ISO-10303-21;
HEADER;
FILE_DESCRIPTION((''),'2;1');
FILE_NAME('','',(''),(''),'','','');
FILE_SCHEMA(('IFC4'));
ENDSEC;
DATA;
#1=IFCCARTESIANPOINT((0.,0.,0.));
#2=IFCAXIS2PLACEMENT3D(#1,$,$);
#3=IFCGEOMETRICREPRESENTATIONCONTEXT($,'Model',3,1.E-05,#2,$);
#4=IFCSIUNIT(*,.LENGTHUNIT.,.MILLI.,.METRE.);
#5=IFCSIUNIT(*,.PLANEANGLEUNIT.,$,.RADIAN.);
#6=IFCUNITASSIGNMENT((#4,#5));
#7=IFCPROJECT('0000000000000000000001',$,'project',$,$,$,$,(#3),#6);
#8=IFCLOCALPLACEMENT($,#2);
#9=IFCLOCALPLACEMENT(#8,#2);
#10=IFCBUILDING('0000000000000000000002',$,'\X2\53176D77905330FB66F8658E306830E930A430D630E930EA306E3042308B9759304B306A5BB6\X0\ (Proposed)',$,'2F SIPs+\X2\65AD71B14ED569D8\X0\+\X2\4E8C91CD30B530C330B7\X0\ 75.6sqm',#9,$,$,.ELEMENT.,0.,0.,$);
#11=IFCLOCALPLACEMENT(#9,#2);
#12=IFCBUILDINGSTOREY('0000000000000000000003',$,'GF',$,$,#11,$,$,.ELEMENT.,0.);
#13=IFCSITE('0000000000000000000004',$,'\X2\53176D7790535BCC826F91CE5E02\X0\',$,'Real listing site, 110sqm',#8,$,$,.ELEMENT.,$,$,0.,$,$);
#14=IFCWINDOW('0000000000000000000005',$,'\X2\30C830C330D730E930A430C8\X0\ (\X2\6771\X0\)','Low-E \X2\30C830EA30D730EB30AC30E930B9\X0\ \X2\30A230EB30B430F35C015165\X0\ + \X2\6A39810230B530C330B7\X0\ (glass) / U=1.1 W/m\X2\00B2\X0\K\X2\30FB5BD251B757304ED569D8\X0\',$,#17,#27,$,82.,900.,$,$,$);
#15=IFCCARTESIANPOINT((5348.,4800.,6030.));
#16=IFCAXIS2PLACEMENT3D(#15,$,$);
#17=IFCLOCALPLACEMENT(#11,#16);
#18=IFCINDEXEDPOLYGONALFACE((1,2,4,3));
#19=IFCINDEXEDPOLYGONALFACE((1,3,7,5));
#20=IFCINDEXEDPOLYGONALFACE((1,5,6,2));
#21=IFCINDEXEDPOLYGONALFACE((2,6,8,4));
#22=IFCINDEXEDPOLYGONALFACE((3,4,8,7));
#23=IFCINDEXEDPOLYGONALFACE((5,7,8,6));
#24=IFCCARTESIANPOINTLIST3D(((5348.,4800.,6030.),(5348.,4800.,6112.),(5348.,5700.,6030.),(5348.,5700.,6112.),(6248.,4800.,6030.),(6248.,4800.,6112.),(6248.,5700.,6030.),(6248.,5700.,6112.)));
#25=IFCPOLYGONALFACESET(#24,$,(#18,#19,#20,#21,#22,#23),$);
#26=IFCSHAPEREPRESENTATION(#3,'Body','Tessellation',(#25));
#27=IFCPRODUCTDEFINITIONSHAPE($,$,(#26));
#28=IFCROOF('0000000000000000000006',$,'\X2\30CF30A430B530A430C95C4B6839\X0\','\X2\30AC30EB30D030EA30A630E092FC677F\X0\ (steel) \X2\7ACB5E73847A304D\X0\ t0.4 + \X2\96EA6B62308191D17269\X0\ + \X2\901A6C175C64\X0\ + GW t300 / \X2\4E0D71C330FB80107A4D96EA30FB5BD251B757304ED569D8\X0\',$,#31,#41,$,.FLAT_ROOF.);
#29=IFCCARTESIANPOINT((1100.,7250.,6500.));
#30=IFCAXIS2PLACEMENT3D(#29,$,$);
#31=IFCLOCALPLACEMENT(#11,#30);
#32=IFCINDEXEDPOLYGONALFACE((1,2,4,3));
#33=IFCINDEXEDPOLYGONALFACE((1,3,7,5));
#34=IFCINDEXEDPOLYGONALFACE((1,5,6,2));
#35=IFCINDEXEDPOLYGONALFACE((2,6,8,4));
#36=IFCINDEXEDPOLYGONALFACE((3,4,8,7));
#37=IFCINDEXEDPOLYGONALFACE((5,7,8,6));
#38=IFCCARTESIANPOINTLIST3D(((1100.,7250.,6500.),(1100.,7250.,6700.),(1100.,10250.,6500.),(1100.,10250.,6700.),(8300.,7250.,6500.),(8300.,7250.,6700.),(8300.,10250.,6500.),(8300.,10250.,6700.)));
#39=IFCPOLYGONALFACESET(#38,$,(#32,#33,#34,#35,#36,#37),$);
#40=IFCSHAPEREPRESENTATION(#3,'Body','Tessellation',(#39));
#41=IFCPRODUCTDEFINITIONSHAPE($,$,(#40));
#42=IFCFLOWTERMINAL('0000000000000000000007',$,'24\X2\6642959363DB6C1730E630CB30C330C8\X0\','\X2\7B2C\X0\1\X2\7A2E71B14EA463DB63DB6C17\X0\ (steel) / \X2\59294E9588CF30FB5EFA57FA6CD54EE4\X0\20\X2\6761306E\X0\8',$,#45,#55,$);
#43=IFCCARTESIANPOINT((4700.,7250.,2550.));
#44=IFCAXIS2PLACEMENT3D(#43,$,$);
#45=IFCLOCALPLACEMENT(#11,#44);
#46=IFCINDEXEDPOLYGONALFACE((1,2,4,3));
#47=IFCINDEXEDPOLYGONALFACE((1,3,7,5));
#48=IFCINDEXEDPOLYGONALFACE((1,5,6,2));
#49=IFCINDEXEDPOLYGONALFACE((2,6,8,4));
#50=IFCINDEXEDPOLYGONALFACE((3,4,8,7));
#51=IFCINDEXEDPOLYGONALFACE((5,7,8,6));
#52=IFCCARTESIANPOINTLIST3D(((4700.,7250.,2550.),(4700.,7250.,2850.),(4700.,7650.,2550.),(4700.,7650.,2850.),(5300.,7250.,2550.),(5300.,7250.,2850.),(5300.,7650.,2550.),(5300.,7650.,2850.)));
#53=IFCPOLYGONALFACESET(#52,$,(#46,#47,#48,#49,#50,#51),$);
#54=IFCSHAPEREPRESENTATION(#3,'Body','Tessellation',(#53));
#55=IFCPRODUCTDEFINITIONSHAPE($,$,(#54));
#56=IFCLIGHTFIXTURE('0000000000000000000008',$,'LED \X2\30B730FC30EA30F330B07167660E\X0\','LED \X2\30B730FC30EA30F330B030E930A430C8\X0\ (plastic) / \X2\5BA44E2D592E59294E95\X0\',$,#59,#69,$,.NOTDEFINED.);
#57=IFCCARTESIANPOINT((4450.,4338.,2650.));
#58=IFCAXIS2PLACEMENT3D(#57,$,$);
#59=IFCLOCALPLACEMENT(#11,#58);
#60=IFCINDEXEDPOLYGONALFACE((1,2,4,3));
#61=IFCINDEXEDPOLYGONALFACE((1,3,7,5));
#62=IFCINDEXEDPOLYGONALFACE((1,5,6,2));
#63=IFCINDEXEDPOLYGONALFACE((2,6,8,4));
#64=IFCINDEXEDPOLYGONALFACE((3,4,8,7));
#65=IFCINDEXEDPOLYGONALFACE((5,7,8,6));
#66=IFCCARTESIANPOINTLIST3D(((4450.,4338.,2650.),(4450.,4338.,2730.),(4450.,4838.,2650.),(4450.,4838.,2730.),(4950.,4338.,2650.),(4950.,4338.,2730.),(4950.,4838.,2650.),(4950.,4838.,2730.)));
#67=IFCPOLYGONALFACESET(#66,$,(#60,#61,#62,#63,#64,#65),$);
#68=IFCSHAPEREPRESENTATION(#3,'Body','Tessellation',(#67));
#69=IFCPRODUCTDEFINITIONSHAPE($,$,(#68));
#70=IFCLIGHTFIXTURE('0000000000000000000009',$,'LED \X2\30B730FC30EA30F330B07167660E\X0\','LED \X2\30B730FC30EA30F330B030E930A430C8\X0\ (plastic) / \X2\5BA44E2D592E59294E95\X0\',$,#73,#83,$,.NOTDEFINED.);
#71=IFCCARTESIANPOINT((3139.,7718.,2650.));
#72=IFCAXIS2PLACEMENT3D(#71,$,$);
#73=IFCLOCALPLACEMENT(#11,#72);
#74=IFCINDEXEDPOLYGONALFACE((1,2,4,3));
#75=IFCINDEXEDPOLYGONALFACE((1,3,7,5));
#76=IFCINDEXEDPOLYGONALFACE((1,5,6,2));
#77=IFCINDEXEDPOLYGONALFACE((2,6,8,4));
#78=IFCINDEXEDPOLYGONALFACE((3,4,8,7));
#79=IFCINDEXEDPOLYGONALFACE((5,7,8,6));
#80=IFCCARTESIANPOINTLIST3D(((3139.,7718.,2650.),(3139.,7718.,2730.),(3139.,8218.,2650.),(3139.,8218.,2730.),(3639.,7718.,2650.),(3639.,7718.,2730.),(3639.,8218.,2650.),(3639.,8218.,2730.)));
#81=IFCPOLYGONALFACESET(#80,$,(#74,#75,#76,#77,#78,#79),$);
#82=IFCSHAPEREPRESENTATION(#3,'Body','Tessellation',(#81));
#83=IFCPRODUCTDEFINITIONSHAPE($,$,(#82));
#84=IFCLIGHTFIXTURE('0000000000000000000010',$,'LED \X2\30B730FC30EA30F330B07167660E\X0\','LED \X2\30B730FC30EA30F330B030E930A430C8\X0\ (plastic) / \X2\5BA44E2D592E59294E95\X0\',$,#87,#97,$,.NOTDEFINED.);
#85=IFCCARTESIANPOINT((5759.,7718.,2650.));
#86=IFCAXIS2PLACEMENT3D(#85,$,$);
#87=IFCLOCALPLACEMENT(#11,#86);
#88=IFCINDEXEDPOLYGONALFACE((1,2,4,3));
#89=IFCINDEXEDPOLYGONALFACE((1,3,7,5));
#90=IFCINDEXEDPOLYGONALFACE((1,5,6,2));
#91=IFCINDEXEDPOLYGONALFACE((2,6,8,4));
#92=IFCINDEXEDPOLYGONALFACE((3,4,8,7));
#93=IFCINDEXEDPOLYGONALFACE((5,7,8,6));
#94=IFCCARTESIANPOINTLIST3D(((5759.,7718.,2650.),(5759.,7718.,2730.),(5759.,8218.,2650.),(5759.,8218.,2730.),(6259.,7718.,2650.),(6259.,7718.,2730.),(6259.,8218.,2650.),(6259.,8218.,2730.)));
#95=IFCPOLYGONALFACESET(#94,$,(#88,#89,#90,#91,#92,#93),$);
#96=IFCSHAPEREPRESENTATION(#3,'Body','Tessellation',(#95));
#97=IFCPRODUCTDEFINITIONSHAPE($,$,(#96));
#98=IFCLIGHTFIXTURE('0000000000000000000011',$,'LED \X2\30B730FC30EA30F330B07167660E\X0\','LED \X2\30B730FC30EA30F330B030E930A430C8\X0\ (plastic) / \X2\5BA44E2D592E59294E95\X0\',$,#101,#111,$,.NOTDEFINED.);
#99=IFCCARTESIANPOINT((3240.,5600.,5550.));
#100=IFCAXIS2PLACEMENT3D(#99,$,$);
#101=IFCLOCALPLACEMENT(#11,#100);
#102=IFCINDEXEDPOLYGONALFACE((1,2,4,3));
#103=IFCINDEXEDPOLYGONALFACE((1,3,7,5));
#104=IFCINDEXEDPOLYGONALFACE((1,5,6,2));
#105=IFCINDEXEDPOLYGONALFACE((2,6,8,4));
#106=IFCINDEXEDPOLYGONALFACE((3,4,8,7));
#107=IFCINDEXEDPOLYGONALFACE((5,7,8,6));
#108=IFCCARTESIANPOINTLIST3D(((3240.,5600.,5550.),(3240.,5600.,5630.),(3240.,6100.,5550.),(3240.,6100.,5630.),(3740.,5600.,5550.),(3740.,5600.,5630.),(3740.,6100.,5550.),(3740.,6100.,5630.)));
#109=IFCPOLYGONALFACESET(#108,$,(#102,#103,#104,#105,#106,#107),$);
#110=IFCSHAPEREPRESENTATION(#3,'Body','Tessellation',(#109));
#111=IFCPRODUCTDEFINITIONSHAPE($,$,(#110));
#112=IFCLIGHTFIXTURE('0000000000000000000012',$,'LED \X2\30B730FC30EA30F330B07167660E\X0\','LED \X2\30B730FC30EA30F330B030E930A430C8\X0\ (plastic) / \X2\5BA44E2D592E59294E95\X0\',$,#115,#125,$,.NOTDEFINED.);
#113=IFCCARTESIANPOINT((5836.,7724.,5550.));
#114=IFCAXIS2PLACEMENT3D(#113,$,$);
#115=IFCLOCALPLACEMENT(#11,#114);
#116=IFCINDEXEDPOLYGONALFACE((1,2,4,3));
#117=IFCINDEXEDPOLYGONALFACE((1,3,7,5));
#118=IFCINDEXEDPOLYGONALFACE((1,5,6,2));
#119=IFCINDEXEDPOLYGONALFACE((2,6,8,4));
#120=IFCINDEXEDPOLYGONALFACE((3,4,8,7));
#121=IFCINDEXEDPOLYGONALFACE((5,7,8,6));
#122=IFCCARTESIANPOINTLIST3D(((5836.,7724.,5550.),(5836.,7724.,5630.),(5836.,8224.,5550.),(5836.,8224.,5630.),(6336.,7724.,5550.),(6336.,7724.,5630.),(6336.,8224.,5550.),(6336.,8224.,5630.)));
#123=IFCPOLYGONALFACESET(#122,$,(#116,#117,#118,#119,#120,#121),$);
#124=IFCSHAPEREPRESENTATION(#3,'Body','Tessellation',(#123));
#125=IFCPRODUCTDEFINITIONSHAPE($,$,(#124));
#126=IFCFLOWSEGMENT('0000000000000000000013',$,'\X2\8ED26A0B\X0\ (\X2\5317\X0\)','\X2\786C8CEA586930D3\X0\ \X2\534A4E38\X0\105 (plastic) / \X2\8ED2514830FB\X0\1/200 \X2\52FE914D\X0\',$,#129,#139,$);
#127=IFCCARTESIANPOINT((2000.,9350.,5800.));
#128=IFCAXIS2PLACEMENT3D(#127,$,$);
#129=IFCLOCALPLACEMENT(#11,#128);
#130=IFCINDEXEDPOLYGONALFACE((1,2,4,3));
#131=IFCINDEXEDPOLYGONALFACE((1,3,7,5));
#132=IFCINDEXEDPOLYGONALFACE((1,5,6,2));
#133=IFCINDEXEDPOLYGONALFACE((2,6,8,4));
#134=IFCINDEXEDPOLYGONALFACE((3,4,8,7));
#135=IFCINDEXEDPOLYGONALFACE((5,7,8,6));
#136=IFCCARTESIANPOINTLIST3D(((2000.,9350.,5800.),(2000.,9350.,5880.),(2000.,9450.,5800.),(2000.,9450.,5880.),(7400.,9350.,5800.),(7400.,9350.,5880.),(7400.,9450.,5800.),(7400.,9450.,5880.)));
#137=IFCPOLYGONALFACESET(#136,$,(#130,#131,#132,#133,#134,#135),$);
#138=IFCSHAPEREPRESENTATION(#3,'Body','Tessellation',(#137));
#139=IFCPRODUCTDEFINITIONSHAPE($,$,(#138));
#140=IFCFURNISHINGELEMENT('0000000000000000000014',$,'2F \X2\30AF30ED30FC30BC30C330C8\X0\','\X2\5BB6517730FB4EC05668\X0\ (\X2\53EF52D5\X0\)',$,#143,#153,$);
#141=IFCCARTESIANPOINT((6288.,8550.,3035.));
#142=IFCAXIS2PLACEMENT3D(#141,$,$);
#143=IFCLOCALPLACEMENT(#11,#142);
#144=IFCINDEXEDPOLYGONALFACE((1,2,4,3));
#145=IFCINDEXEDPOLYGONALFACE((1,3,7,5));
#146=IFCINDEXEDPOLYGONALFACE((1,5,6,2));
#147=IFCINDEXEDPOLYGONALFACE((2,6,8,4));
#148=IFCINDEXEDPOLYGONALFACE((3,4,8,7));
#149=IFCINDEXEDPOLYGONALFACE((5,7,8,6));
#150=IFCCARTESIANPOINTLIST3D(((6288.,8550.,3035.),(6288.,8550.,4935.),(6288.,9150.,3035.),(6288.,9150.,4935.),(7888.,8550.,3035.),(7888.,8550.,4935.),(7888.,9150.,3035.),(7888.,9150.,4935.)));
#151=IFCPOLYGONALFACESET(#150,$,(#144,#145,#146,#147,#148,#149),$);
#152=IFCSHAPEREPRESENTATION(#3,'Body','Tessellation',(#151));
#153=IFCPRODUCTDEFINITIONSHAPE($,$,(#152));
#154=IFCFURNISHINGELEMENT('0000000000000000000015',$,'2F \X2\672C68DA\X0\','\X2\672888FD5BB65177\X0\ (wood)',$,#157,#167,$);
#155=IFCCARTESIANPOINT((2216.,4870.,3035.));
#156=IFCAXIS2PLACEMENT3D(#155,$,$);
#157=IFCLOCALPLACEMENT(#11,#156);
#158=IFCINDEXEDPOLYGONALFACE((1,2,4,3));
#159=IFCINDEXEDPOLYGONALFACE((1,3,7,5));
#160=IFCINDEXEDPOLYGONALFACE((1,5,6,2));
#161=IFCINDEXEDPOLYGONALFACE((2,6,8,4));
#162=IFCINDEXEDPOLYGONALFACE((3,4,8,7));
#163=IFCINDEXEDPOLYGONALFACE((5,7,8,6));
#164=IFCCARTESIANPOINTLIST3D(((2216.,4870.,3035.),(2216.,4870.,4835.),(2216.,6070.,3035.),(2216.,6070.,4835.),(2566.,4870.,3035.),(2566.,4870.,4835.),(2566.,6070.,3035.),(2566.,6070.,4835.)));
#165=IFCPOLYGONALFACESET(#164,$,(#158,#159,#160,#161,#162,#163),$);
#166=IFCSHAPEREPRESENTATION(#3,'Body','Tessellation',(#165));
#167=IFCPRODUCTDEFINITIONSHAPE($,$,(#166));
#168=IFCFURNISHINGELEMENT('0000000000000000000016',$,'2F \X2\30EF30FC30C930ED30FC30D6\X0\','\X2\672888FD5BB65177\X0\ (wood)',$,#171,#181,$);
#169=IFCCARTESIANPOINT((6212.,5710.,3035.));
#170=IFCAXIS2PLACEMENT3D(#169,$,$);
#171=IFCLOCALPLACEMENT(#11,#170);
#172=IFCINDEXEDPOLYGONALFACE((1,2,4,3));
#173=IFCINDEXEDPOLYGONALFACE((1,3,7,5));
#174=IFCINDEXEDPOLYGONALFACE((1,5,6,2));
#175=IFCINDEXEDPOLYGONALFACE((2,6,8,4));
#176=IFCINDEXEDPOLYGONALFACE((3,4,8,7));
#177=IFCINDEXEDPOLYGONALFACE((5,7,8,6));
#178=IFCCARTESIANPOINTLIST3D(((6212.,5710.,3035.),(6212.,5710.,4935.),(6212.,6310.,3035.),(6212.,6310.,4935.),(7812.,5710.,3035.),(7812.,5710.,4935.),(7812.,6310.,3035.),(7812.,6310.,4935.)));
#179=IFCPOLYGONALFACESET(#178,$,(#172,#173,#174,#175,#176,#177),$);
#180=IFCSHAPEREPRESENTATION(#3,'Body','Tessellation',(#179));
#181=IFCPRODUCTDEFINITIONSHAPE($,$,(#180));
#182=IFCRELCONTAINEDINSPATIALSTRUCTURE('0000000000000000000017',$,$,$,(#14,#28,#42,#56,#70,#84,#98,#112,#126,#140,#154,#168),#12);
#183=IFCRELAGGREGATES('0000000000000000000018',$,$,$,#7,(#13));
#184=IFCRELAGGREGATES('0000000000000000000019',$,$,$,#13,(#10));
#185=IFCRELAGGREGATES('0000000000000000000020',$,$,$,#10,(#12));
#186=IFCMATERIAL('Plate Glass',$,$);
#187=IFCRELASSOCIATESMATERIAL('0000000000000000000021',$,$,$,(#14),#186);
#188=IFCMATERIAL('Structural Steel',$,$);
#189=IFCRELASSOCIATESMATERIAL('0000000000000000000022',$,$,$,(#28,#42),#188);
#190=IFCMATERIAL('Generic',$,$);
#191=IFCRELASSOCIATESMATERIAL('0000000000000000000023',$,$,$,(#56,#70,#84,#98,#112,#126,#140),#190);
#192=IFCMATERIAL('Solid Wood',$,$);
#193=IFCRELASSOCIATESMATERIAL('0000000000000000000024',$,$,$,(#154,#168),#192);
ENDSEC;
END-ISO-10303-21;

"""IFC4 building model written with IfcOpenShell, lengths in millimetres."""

from ifc_helpers import new_model, si_unit, frame, frame_2d, origin, place, context, project, spatial, rectangle, extrude, material, element, save


model = new_model("IFC4")

# Units and contexts
model_context = context("Model", 3, precision=1e-05, world=origin())
ifc_project = project(units=[si_unit("LENGTHUNIT", "METRE", prefix="MILLI"), si_unit("PLANEANGLEUNIT", "RADIAN")], contexts=[model_context])

# Site, building, storey
site_placement = place(None, origin())
site = spatial("IfcSite", under=ifc_project, at=site_placement, Name="北海道富良野市", ObjectType="Real listing site, 110sqm", CompositionType="ELEMENT", RefElevation=0.0)
building_placement = place(site_placement, origin())
building = spatial("IfcBuilding", under=site, at=building_placement, Name="北海道・書斎とライブラリのある静かな家 (Proposed)", ObjectType="2F SIPs+断熱仕様+二重サッシ 75.6sqm", CompositionType="ELEMENT", ElevationOfRefHeight=0.0, ElevationOfTerrain=0.0)
storey_placement = place(building_placement, origin())
storey = spatial("IfcBuildingStorey", under=building, at=storey_placement, Name="GF", CompositionType="ELEMENT", Elevation=0.0)

# Shared definitions
ifc_material_1 = material(Name="Solid Wood")

# Shared definitions
ifc_material_2 = material(Name="Plate Glass")

# Window
window_1_placement = place(storey_placement, frame((5348.0, 4800.0, 6030.0)))
element("IfcWindow", 1, at=window_1_placement, inside=storey, material=ifc_material_2, Name="トップライト (東)", Description="Low-E トリプルガラス アルゴン封入 + 樹脂サッシ (glass) / U=1.1 W/m²K・寒冷地仕様", OverallHeight=82.0, OverallWidth=900.0, context=model_context, shape_type="SweptSolid", body=[
    extrude(rectangle(XDim=900.0, YDim=900.0, at=frame_2d((450.0, 450.0))), frame((5348.0, 4800.0, 6030.0)), (0.0, 0.0, 1.0), 82.0),
])

# Roof
ifc_material_3 = material(Name="Structural Steel")
roof_placement = place(storey_placement, frame((1100.0, 7250.0, 6500.0)))
element("IfcRoof", 2, at=roof_placement, inside=storey, material=ifc_material_3, Name="ハイサイド屋根", Description="ガルバリウム鋼板 (steel) 立平葺き t0.4 + 雪止め金物 + 通気層 + GW t300 / 不燃・耐積雪・寒冷地仕様", PredefinedType="FLAT_ROOF", context=model_context, shape_type="SweptSolid", body=[
    extrude(rectangle(XDim=7200.0, YDim=3000.0, at=frame_2d((3600.0, 1500.0))), frame((1100.0, 7250.0, 6500.0)), (0.0, 0.0, 1.0), 200.0),
])

# Flow terminal
flow_terminal_placement = place(storey_placement, frame((4700.0, 7250.0, 2550.0)))
element("IfcFlowTerminal", 3, at=flow_terminal_placement, inside=storey, material=ifc_material_3, Name="24時間換気ユニット", Description="第1種熱交換換気 (steel) / 天井裏・建基法令20条の8", context=model_context, shape_type="SweptSolid", body=[
    extrude(rectangle(XDim=600.0, YDim=400.0, at=frame_2d((300.0, 200.0))), frame((4700.0, 7250.0, 2550.0)), (0.0, 0.0, 1.0), 300.0),
])

# Light fixtures
ifc_material_4 = material(Name="Generic")
light_fixture_1_placement = place(storey_placement, frame((4450.0, 4338.0, 2650.0)))
element("IfcLightFixture", 4, at=light_fixture_1_placement, inside=storey, material=ifc_material_4, Name="LED シーリング照明", Description="LED シーリングライト (plastic) / 室中央天井", PredefinedType="NOTDEFINED", context=model_context, shape_type="SweptSolid", body=[
    extrude(rectangle(XDim=500.0, YDim=500.0, at=frame_2d((250.0, 250.0))), frame((4450.0, 4338.0, 2650.0)), (0.0, 0.0, 1.0), 80.0),
])
light_fixture_2_placement = place(storey_placement, frame((3139.0, 7718.0, 2650.0)))
element("IfcLightFixture", 5, at=light_fixture_2_placement, inside=storey, material=ifc_material_4, Name="LED シーリング照明", Description="LED シーリングライト (plastic) / 室中央天井", PredefinedType="NOTDEFINED", context=model_context, shape_type="SweptSolid", body=[
    extrude(rectangle(XDim=500.0, YDim=500.0, at=frame_2d((250.0, 250.0))), frame((3139.0, 7718.0, 2650.0)), (0.0, 0.0, 1.0), 80.0),
])
light_fixture_3_placement = place(storey_placement, frame((5759.0, 7718.0, 2650.0)))
element("IfcLightFixture", 6, at=light_fixture_3_placement, inside=storey, material=ifc_material_4, Name="LED シーリング照明", Description="LED シーリングライト (plastic) / 室中央天井", PredefinedType="NOTDEFINED", context=model_context, shape_type="SweptSolid", body=[
    extrude(rectangle(XDim=500.0, YDim=500.0, at=frame_2d((250.0, 250.0))), frame((5759.0, 7718.0, 2650.0)), (0.0, 0.0, 1.0), 80.0),
])
light_fixture_4_placement = place(storey_placement, frame((3240.0, 5600.0, 5550.0)))
element("IfcLightFixture", 7, at=light_fixture_4_placement, inside=storey, material=ifc_material_4, Name="LED シーリング照明", Description="LED シーリングライト (plastic) / 室中央天井", PredefinedType="NOTDEFINED", context=model_context, shape_type="SweptSolid", body=[
    extrude(rectangle(XDim=500.0, YDim=500.0, at=frame_2d((250.0, 250.0))), frame((3240.0, 5600.0, 5550.0)), (0.0, 0.0, 1.0), 80.0),
])
light_fixture_5_placement = place(storey_placement, frame((5836.0, 7724.0, 5550.0)))
element("IfcLightFixture", 8, at=light_fixture_5_placement, inside=storey, material=ifc_material_4, Name="LED シーリング照明", Description="LED シーリングライト (plastic) / 室中央天井", PredefinedType="NOTDEFINED", context=model_context, shape_type="SweptSolid", body=[
    extrude(rectangle(XDim=500.0, YDim=500.0, at=frame_2d((250.0, 250.0))), frame((5836.0, 7724.0, 5550.0)), (0.0, 0.0, 1.0), 80.0),
])

# Flow segment
flow_segment_placement = place(storey_placement, frame((2000.0, 9350.0, 5800.0)))
element("IfcFlowSegment", 9, at=flow_segment_placement, inside=storey, material=ifc_material_4, Name="軒樋 (北)", Description="硬質塩ビ 半丸105 (plastic) / 軒先・1/200 勾配", context=model_context, shape_type="SweptSolid", body=[
    extrude(rectangle(XDim=5400.0, YDim=100.0, at=frame_2d((2700.0, 50.0))), frame((2000.0, 9350.0, 5800.0)), (0.0, 0.0, 1.0), 80.0),
])

# Furnishing elements
furnishing_1_placement = place(storey_placement, frame((6288.0, 8550.0, 3035.0)))
element("IfcFurnishingElement", 10, at=furnishing_1_placement, inside=storey, material=ifc_material_4, Name="2F クローゼット", Description="家具・什器 (可動)", context=model_context, shape_type="SweptSolid", body=[
    extrude(rectangle(XDim=1600.0, YDim=600.0, at=frame_2d((800.0, 300.0))), frame((6288.0, 8550.0, 3035.0)), (0.0, 0.0, 1.0), 1900.0),
])
furnishing_2_placement = place(storey_placement, frame((2216.0, 4870.0, 3035.0)))
element("IfcFurnishingElement", 11, at=furnishing_2_placement, inside=storey, material=ifc_material_1, Name="2F 本棚", Description="木製家具 (wood)", context=model_context, shape_type="SweptSolid", body=[
    extrude(rectangle(XDim=350.0, YDim=1200.0, at=frame_2d((175.0, 600.0))), frame((2216.0, 4870.0, 3035.0)), (0.0, 0.0, 1.0), 1800.0),
])
furnishing_3_placement = place(storey_placement, frame((6212.0, 5710.0, 3035.0)))
element("IfcFurnishingElement", 12, at=furnishing_3_placement, inside=storey, material=ifc_material_1, Name="2F ワードローブ", Description="木製家具 (wood)", context=model_context, shape_type="SweptSolid", body=[
    extrude(rectangle(XDim=1600.0, YDim=600.0, at=frame_2d((800.0, 300.0))), frame((6212.0, 5710.0, 3035.0)), (0.0, 0.0, 1.0), 1900.0),
])

save(model, "model.ifc")
